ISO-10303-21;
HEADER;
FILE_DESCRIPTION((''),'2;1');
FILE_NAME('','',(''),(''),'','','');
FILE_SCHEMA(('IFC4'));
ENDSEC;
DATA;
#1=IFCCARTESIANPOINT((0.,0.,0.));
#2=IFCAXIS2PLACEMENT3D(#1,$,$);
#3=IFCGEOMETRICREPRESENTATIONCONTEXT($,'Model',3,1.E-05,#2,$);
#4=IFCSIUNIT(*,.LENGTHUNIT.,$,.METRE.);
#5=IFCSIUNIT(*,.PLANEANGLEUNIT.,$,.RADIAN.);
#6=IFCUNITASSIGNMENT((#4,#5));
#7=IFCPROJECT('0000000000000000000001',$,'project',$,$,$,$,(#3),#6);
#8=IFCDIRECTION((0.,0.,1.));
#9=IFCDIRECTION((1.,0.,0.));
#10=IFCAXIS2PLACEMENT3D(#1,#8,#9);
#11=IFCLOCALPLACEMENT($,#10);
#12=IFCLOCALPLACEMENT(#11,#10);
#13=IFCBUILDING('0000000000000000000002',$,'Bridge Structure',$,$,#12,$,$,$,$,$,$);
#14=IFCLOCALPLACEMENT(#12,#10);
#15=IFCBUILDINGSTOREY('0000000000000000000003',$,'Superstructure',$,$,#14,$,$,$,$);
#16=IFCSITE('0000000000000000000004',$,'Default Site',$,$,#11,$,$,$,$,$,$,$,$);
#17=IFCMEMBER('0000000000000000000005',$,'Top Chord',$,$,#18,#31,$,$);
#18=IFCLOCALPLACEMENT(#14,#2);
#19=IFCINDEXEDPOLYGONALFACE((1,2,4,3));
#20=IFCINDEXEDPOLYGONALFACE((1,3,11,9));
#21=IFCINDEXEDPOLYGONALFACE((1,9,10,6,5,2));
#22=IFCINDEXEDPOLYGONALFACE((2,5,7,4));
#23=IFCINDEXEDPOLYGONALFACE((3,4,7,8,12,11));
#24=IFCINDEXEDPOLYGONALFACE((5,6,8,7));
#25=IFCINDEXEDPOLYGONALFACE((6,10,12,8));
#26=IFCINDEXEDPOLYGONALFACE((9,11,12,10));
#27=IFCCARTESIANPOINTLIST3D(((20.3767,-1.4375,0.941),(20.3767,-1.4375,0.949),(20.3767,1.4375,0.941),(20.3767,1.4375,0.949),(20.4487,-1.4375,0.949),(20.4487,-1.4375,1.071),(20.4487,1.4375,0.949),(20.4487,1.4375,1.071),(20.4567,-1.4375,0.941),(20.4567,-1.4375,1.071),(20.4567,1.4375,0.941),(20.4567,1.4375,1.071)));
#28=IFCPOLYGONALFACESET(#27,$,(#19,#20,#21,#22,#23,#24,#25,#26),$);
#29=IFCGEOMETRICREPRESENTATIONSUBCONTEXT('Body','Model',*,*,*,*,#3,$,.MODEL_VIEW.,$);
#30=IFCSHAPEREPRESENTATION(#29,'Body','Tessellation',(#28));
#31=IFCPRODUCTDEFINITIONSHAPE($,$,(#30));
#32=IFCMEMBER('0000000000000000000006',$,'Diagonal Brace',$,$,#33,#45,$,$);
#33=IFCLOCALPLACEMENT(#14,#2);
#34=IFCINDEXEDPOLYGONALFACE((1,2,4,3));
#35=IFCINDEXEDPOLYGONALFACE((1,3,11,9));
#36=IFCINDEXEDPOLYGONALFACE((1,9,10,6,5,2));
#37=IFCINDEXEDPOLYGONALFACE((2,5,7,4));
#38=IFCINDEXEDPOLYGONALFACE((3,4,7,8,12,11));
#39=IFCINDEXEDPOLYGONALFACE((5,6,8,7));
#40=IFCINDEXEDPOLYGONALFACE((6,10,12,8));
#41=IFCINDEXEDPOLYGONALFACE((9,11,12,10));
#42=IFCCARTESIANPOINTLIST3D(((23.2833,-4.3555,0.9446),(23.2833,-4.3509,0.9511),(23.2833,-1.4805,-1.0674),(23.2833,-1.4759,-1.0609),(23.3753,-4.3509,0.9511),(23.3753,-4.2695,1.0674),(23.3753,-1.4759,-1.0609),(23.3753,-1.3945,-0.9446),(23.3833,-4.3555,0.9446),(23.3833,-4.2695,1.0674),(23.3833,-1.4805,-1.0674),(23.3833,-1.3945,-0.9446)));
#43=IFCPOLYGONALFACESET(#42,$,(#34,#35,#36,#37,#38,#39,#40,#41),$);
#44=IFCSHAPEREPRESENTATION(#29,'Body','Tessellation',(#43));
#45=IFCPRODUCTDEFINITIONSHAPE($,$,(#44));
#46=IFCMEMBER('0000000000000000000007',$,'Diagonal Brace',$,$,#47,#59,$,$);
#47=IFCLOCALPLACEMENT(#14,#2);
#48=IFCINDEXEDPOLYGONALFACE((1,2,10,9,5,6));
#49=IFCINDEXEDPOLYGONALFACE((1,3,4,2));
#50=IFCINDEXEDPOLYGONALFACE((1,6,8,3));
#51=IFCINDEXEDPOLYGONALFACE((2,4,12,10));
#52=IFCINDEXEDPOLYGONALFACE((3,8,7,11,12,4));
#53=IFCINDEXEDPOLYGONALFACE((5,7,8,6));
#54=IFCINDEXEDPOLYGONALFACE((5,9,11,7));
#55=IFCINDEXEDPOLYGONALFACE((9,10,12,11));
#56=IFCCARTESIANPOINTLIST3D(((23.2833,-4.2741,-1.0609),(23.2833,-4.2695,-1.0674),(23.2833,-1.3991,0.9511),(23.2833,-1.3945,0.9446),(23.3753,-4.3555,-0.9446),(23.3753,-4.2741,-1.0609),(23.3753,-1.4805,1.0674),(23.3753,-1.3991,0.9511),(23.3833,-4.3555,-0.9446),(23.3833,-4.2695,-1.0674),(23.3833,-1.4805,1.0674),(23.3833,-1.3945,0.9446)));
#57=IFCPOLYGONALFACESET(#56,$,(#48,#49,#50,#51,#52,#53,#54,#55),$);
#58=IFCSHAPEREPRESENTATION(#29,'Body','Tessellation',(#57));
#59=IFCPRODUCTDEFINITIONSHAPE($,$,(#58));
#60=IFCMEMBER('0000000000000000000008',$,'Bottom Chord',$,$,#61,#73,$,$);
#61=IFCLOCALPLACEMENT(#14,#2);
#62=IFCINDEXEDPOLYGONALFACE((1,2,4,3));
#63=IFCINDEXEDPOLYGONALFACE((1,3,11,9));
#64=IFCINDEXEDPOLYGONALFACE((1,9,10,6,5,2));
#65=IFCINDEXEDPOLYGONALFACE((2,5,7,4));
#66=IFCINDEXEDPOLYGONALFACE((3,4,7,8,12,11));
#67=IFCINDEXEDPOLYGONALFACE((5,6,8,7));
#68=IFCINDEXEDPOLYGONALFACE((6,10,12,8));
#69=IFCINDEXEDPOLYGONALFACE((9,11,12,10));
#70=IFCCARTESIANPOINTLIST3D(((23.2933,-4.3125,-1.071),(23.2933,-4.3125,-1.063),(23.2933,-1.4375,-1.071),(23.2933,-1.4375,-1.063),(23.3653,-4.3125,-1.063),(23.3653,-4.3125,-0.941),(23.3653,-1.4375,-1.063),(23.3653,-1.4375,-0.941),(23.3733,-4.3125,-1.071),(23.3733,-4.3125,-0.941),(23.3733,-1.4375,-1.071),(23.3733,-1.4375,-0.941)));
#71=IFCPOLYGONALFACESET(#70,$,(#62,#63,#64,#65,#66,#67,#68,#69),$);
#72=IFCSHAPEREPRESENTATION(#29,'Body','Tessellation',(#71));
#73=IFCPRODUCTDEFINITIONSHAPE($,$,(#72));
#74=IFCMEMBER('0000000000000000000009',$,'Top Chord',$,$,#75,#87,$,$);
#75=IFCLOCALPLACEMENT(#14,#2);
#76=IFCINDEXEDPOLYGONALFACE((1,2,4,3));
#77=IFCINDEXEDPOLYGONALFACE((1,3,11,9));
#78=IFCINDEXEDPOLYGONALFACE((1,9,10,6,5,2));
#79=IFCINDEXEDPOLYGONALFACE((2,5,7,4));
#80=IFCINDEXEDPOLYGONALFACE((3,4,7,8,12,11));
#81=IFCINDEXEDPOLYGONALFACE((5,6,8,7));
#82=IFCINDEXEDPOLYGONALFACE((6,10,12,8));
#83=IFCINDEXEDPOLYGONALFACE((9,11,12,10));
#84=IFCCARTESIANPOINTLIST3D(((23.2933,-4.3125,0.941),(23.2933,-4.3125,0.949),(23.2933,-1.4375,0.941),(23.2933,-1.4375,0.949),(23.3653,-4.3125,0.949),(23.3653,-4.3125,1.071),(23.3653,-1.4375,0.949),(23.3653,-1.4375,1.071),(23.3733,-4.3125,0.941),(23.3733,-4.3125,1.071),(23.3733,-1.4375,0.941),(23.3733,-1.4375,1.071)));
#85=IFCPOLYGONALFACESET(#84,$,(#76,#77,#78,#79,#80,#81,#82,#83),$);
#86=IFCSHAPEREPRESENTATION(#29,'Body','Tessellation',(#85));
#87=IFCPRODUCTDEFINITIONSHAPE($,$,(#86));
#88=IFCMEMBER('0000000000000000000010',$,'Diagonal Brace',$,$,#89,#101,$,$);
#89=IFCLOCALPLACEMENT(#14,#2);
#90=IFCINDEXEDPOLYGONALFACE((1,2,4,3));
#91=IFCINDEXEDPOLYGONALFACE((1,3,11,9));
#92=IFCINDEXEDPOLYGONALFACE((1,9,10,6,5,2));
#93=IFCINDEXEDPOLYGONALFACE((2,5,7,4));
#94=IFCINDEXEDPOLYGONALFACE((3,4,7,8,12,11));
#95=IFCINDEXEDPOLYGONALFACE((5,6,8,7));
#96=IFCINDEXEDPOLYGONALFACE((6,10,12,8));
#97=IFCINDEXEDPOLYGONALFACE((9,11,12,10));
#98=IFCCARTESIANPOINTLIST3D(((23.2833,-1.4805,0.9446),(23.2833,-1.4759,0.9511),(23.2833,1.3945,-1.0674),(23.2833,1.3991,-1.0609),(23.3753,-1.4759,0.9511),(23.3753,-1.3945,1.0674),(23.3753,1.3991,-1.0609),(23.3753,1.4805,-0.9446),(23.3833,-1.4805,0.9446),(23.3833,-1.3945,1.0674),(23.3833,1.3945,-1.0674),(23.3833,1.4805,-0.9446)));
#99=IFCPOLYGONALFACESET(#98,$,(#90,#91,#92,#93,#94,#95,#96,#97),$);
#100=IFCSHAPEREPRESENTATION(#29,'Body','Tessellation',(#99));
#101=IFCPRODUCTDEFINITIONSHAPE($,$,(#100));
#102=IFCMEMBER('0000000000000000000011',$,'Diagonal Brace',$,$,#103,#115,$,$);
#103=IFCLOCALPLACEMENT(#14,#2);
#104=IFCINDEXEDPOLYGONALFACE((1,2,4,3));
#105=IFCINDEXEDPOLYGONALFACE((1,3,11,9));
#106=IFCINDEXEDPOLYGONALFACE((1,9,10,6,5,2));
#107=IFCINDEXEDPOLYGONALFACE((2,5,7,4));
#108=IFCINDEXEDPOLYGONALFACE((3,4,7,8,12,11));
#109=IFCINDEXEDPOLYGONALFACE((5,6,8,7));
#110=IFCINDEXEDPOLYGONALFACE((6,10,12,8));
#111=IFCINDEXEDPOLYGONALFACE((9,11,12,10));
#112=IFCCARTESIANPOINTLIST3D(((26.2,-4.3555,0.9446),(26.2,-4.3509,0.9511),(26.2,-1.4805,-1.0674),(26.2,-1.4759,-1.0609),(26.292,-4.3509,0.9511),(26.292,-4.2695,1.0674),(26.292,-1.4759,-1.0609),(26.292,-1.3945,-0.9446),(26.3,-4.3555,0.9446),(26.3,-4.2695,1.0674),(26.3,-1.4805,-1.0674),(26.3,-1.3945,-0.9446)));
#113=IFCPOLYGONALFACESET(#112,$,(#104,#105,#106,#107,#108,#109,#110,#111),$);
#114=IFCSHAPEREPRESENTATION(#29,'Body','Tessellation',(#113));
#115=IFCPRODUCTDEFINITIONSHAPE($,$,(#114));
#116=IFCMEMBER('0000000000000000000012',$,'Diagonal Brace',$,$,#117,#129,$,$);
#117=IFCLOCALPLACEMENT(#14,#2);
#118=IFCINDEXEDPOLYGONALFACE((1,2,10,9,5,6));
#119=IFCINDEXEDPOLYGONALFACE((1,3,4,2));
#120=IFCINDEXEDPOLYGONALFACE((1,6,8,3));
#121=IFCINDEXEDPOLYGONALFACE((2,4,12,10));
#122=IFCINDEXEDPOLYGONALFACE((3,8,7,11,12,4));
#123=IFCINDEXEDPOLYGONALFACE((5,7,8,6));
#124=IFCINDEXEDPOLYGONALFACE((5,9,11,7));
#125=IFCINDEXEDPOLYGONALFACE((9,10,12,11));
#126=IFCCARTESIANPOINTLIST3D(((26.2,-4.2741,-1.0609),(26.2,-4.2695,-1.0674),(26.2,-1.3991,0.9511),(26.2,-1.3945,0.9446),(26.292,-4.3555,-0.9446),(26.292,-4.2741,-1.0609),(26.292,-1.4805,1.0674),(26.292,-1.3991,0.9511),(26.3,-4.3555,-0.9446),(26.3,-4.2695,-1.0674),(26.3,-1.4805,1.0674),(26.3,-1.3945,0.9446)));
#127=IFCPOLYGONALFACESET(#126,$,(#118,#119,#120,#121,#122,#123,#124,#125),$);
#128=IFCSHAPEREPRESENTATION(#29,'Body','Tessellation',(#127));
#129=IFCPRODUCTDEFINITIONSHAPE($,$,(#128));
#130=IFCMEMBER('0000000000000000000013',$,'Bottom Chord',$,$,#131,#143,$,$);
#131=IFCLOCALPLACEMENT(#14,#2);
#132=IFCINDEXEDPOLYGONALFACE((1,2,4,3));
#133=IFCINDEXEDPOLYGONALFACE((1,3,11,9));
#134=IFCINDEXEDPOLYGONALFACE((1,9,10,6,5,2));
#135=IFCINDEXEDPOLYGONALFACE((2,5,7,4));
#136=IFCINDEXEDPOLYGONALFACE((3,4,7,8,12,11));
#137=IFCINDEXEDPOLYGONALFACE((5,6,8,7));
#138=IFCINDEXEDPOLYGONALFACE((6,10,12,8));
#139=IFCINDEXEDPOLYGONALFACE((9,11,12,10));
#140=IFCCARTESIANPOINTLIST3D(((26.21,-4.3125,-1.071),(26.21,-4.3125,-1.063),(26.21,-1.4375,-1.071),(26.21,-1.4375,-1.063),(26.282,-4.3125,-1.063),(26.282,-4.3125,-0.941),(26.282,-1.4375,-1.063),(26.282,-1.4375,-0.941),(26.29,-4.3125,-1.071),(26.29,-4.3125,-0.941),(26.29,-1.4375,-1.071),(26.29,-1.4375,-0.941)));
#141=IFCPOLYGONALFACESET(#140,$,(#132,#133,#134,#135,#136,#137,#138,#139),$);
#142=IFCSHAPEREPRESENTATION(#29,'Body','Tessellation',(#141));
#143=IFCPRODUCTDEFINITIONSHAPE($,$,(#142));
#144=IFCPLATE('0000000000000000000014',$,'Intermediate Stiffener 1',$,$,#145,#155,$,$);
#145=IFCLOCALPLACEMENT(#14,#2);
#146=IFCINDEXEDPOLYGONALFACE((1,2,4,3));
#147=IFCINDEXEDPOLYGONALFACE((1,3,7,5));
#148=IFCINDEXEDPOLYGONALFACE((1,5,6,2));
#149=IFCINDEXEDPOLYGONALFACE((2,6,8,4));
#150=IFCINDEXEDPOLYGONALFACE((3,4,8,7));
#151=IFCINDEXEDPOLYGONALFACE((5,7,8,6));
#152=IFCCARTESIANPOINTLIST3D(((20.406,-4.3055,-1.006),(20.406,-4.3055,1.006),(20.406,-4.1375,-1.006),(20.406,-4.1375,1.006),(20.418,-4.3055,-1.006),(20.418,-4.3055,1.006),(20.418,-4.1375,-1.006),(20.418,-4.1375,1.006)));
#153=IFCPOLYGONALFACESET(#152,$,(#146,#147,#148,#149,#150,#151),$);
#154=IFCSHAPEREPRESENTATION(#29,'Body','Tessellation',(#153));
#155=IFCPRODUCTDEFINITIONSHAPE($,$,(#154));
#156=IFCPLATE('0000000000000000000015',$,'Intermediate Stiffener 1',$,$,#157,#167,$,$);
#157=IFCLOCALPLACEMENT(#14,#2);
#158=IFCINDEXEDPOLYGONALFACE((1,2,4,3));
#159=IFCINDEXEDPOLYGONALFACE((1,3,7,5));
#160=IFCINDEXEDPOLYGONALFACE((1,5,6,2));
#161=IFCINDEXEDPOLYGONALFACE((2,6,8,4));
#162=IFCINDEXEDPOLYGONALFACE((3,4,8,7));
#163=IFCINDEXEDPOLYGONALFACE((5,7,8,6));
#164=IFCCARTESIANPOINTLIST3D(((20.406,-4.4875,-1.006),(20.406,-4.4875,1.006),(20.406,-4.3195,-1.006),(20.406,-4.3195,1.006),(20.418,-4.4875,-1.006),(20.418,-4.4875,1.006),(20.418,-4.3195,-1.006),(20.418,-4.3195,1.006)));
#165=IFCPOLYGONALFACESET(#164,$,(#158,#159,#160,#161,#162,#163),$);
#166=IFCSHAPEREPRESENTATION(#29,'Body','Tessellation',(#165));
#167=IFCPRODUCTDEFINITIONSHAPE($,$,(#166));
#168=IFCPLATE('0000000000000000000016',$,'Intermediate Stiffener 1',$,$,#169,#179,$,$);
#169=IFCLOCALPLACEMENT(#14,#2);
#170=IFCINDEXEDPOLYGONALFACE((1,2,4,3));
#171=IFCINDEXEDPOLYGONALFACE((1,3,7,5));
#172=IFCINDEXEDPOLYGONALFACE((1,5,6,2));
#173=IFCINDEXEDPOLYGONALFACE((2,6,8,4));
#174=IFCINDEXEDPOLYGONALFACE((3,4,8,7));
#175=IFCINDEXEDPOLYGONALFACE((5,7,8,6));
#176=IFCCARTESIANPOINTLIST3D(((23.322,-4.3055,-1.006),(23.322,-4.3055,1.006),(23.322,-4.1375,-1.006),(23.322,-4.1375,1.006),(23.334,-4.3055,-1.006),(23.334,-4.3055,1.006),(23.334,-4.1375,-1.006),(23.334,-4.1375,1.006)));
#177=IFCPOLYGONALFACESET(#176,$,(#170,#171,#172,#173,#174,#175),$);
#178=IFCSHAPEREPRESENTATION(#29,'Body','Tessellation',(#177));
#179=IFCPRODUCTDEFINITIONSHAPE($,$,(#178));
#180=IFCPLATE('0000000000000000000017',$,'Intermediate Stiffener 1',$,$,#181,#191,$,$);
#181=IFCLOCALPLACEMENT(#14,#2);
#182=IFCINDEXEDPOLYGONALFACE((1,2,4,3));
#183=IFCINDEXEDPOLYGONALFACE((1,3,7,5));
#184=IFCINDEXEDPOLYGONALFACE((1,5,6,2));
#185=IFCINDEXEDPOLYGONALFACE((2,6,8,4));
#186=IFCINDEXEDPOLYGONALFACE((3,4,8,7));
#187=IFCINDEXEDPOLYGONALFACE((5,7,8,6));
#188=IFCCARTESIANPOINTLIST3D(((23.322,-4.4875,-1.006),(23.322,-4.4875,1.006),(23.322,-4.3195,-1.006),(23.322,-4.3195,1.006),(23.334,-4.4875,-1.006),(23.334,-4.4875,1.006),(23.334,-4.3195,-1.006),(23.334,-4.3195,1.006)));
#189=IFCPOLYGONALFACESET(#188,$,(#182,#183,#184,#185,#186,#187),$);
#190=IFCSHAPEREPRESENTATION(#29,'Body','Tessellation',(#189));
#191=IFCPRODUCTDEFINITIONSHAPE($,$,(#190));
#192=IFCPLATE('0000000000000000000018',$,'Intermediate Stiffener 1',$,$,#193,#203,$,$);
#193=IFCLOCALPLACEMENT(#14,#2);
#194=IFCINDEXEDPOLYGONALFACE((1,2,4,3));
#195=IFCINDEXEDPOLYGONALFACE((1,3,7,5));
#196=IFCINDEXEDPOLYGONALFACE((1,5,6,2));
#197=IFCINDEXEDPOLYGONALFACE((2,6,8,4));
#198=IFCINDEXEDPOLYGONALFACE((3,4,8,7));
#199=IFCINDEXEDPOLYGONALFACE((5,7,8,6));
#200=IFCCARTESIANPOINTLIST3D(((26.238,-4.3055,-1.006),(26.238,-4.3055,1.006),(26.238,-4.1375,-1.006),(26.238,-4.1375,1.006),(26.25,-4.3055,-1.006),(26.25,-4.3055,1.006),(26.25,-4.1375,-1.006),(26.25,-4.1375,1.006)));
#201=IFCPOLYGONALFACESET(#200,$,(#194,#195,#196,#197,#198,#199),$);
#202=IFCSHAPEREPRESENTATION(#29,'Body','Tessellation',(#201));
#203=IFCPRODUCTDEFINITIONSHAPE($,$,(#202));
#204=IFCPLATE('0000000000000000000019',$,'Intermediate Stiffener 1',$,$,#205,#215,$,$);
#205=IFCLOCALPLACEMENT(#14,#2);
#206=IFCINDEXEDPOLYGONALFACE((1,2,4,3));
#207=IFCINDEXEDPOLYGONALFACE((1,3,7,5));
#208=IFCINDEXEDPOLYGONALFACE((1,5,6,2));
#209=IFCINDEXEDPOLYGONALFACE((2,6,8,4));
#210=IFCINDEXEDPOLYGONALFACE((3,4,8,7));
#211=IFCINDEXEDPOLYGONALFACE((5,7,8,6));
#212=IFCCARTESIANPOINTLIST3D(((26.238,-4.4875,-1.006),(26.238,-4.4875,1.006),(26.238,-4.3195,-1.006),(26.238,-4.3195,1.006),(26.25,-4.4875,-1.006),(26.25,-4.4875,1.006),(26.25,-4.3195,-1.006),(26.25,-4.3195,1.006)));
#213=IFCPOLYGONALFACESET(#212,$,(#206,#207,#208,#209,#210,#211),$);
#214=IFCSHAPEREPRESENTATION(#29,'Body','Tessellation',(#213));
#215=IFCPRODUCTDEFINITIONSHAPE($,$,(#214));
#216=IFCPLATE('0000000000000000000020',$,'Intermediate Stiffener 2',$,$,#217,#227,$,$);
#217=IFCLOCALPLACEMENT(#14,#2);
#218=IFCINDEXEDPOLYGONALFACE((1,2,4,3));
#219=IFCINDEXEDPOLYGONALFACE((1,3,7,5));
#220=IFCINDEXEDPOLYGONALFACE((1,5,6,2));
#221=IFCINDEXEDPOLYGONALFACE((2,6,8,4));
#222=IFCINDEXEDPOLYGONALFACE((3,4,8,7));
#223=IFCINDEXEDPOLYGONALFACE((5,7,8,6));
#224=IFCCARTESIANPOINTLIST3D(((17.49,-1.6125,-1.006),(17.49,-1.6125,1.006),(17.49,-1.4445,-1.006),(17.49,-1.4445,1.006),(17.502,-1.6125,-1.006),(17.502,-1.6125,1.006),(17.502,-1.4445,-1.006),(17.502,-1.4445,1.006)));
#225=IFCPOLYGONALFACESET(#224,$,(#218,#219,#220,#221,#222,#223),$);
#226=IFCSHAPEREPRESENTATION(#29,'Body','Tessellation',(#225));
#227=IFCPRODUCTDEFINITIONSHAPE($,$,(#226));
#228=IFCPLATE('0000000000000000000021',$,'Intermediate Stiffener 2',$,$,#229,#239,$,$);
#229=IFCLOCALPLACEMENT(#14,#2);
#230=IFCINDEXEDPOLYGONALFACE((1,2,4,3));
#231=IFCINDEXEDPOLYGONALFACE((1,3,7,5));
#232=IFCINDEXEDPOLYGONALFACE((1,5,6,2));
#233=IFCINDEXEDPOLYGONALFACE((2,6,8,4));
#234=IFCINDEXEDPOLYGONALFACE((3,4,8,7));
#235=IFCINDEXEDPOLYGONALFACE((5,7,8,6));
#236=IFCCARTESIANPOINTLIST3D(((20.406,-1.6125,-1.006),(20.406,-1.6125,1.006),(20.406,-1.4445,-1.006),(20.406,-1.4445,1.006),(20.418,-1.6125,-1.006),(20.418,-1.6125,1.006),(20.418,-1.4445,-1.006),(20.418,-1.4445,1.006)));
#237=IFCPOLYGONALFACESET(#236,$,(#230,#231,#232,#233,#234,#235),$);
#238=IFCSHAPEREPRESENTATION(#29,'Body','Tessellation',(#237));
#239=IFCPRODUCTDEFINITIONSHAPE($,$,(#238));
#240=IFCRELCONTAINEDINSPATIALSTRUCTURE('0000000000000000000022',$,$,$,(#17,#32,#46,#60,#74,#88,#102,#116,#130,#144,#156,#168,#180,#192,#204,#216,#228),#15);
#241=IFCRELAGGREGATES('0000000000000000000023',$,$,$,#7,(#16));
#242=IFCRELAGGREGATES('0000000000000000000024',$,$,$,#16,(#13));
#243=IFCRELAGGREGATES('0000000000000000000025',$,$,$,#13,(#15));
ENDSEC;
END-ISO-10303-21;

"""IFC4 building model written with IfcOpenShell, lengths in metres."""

from ifc_helpers import new_model, si_unit, frame, origin, origin_with_axes, origin_2d_with_axis, place, context, subcontext, project, spatial, rectangle, l_section, extrude, element, save


model = new_model("IFC4")

# Units and contexts
model_context = context("Model", 3, precision=1e-05, world=origin())
body_context = subcontext(model_context, "Body", "Model", "MODEL_VIEW")
ifc_project = project(units=[si_unit("LENGTHUNIT", "METRE"), si_unit("PLANEANGLEUNIT", "RADIAN")], contexts=[model_context])

# Site, building, storey
site_placement = place(None, origin_with_axes())
site = spatial("IfcSite", under=ifc_project, at=site_placement, Name="Default Site")
building_placement = place(site_placement, origin_with_axes())
building = spatial("IfcBuilding", under=site, at=building_placement, Name="Bridge Structure")
storey_placement = place(building_placement, origin_with_axes())
storey = spatial("IfcBuildingStorey", under=building, at=storey_placement, Name="Superstructure")

# Members
for number, where, z_axis, x_axis, name in (
    (1, (20.4167, -1.4375, 1.006), (0.0, 1.0, 0.0), (-1.0, 0.0, 0.0), "Top Chord"),
):
    element("IfcMember", number, at=place(storey_placement, frame(where, z_axis=z_axis, x_axis=x_axis)), inside=storey, Name=name, context=body_context, shape_type="SweptSolid", body=[
        extrude(l_section(Depth=0.13, Width=0.08, Thickness=0.008, at=origin_2d_with_axis()), origin_with_axes(), (0.0, 0.0, 1.0), 2.875),
    ])
for number, where, z_axis, x_axis, name in (
    (2, (23.3333, -4.3125, 1.006), (0.0, 0.819299, -0.573367), (-1.0, 0.0, 0.0), "Diagonal Brace"),
    (3, (23.3333, -4.3125, -1.006), (0.0, 0.819299, 0.573367), (-1.0, 0.0, 0.0), "Diagonal Brace"),
):
    element("IfcMember", number, at=place(storey_placement, frame(where, z_axis=z_axis, x_axis=x_axis)), inside=storey, Name=name, context=body_context, shape_type="SweptSolid", body=[
        extrude(l_section(Depth=0.15, Width=0.1, Thickness=0.008, at=origin_2d_with_axis()), origin_with_axes(), (0.0, 0.0, 1.0), 3.5091),
    ])
for number, where, z_axis, x_axis, name in (
    (4, (23.3333, -4.3125, -1.006), (0.0, 1.0, 0.0), (-1.0, 0.0, 0.0), "Bottom Chord"),
    (5, (23.3333, -4.3125, 1.006), (0.0, 1.0, 0.0), (-1.0, 0.0, 0.0), "Top Chord"),
):
    element("IfcMember", number, at=place(storey_placement, frame(where, z_axis=z_axis, x_axis=x_axis)), inside=storey, Name=name, context=body_context, shape_type="SweptSolid", body=[
        extrude(l_section(Depth=0.13, Width=0.08, Thickness=0.008, at=origin_2d_with_axis()), origin_with_axes(), (0.0, 0.0, 1.0), 2.875),
    ])
for number, where, z_axis, x_axis, name in (
    (6, (23.3333, -1.4375, 1.006), (0.0, 0.819299, -0.573367), (-1.0, 0.0, 0.0), "Diagonal Brace"),
    (7, (26.25, -4.3125, 1.006), (0.0, 0.819299, -0.573367), (-1.0, 0.0, 0.0), "Diagonal Brace"),
    (8, (26.25, -4.3125, -1.006), (0.0, 0.819299, 0.573367), (-1.0, 0.0, 0.0), "Diagonal Brace"),
):
    element("IfcMember", number, at=place(storey_placement, frame(where, z_axis=z_axis, x_axis=x_axis)), inside=storey, Name=name, context=body_context, shape_type="SweptSolid", body=[
        extrude(l_section(Depth=0.15, Width=0.1, Thickness=0.008, at=origin_2d_with_axis()), origin_with_axes(), (0.0, 0.0, 1.0), 3.5091),
    ])
member_placement = place(storey_placement, frame((26.25, -4.3125, -1.006), z_axis=(0.0, 1.0, 0.0), x_axis=(-1.0, 0.0, 0.0)))
element("IfcMember", 9, at=member_placement, inside=storey, Name="Bottom Chord", context=body_context, shape_type="SweptSolid", body=[
    extrude(l_section(Depth=0.13, Width=0.08, Thickness=0.008, at=origin_2d_with_axis()), origin_with_axes(), (0.0, 0.0, 1.0), 2.875),
])

# Plates
for number, where, z_axis, x_axis, name in (
    (10, (20.412, -4.2215, -1.006), (0.0, 0.0, 1.0), (1.0, 0.0, 0.0), "Intermediate Stiffener 1"),
    (11, (20.412, -4.4035, -1.006), (0.0, 0.0, 1.0), (1.0, 0.0, 0.0), "Intermediate Stiffener 1"),
    (12, (23.328, -4.2215, -1.006), (0.0, 0.0, 1.0), (1.0, 0.0, 0.0), "Intermediate Stiffener 1"),
    (13, (23.328, -4.4035, -1.006), (0.0, 0.0, 1.0), (1.0, 0.0, 0.0), "Intermediate Stiffener 1"),
    (14, (26.244, -4.2215, -1.006), (0.0, 0.0, 1.0), (1.0, 0.0, 0.0), "Intermediate Stiffener 1"),
    (15, (26.244, -4.4035, -1.006), (0.0, 0.0, 1.0), (1.0, 0.0, 0.0), "Intermediate Stiffener 1"),
    (16, (17.496, -1.5285, -1.006), (0.0, 0.0, 1.0), (1.0, 0.0, 0.0), "Intermediate Stiffener 2"),
    (17, (20.412, -1.5285, -1.006), (0.0, 0.0, 1.0), (1.0, 0.0, 0.0), "Intermediate Stiffener 2"),
):
    element("IfcPlate", number, at=place(storey_placement, frame(where, z_axis=z_axis, x_axis=x_axis)), inside=storey, Name=name, context=body_context, shape_type="SweptSolid", body=[
        extrude(rectangle(XDim=0.012, YDim=0.168, at=origin_2d_with_axis()), origin_with_axes(), (0.0, 0.0, 1.0), 2.012),
    ])

save(model, "model.ifc")
